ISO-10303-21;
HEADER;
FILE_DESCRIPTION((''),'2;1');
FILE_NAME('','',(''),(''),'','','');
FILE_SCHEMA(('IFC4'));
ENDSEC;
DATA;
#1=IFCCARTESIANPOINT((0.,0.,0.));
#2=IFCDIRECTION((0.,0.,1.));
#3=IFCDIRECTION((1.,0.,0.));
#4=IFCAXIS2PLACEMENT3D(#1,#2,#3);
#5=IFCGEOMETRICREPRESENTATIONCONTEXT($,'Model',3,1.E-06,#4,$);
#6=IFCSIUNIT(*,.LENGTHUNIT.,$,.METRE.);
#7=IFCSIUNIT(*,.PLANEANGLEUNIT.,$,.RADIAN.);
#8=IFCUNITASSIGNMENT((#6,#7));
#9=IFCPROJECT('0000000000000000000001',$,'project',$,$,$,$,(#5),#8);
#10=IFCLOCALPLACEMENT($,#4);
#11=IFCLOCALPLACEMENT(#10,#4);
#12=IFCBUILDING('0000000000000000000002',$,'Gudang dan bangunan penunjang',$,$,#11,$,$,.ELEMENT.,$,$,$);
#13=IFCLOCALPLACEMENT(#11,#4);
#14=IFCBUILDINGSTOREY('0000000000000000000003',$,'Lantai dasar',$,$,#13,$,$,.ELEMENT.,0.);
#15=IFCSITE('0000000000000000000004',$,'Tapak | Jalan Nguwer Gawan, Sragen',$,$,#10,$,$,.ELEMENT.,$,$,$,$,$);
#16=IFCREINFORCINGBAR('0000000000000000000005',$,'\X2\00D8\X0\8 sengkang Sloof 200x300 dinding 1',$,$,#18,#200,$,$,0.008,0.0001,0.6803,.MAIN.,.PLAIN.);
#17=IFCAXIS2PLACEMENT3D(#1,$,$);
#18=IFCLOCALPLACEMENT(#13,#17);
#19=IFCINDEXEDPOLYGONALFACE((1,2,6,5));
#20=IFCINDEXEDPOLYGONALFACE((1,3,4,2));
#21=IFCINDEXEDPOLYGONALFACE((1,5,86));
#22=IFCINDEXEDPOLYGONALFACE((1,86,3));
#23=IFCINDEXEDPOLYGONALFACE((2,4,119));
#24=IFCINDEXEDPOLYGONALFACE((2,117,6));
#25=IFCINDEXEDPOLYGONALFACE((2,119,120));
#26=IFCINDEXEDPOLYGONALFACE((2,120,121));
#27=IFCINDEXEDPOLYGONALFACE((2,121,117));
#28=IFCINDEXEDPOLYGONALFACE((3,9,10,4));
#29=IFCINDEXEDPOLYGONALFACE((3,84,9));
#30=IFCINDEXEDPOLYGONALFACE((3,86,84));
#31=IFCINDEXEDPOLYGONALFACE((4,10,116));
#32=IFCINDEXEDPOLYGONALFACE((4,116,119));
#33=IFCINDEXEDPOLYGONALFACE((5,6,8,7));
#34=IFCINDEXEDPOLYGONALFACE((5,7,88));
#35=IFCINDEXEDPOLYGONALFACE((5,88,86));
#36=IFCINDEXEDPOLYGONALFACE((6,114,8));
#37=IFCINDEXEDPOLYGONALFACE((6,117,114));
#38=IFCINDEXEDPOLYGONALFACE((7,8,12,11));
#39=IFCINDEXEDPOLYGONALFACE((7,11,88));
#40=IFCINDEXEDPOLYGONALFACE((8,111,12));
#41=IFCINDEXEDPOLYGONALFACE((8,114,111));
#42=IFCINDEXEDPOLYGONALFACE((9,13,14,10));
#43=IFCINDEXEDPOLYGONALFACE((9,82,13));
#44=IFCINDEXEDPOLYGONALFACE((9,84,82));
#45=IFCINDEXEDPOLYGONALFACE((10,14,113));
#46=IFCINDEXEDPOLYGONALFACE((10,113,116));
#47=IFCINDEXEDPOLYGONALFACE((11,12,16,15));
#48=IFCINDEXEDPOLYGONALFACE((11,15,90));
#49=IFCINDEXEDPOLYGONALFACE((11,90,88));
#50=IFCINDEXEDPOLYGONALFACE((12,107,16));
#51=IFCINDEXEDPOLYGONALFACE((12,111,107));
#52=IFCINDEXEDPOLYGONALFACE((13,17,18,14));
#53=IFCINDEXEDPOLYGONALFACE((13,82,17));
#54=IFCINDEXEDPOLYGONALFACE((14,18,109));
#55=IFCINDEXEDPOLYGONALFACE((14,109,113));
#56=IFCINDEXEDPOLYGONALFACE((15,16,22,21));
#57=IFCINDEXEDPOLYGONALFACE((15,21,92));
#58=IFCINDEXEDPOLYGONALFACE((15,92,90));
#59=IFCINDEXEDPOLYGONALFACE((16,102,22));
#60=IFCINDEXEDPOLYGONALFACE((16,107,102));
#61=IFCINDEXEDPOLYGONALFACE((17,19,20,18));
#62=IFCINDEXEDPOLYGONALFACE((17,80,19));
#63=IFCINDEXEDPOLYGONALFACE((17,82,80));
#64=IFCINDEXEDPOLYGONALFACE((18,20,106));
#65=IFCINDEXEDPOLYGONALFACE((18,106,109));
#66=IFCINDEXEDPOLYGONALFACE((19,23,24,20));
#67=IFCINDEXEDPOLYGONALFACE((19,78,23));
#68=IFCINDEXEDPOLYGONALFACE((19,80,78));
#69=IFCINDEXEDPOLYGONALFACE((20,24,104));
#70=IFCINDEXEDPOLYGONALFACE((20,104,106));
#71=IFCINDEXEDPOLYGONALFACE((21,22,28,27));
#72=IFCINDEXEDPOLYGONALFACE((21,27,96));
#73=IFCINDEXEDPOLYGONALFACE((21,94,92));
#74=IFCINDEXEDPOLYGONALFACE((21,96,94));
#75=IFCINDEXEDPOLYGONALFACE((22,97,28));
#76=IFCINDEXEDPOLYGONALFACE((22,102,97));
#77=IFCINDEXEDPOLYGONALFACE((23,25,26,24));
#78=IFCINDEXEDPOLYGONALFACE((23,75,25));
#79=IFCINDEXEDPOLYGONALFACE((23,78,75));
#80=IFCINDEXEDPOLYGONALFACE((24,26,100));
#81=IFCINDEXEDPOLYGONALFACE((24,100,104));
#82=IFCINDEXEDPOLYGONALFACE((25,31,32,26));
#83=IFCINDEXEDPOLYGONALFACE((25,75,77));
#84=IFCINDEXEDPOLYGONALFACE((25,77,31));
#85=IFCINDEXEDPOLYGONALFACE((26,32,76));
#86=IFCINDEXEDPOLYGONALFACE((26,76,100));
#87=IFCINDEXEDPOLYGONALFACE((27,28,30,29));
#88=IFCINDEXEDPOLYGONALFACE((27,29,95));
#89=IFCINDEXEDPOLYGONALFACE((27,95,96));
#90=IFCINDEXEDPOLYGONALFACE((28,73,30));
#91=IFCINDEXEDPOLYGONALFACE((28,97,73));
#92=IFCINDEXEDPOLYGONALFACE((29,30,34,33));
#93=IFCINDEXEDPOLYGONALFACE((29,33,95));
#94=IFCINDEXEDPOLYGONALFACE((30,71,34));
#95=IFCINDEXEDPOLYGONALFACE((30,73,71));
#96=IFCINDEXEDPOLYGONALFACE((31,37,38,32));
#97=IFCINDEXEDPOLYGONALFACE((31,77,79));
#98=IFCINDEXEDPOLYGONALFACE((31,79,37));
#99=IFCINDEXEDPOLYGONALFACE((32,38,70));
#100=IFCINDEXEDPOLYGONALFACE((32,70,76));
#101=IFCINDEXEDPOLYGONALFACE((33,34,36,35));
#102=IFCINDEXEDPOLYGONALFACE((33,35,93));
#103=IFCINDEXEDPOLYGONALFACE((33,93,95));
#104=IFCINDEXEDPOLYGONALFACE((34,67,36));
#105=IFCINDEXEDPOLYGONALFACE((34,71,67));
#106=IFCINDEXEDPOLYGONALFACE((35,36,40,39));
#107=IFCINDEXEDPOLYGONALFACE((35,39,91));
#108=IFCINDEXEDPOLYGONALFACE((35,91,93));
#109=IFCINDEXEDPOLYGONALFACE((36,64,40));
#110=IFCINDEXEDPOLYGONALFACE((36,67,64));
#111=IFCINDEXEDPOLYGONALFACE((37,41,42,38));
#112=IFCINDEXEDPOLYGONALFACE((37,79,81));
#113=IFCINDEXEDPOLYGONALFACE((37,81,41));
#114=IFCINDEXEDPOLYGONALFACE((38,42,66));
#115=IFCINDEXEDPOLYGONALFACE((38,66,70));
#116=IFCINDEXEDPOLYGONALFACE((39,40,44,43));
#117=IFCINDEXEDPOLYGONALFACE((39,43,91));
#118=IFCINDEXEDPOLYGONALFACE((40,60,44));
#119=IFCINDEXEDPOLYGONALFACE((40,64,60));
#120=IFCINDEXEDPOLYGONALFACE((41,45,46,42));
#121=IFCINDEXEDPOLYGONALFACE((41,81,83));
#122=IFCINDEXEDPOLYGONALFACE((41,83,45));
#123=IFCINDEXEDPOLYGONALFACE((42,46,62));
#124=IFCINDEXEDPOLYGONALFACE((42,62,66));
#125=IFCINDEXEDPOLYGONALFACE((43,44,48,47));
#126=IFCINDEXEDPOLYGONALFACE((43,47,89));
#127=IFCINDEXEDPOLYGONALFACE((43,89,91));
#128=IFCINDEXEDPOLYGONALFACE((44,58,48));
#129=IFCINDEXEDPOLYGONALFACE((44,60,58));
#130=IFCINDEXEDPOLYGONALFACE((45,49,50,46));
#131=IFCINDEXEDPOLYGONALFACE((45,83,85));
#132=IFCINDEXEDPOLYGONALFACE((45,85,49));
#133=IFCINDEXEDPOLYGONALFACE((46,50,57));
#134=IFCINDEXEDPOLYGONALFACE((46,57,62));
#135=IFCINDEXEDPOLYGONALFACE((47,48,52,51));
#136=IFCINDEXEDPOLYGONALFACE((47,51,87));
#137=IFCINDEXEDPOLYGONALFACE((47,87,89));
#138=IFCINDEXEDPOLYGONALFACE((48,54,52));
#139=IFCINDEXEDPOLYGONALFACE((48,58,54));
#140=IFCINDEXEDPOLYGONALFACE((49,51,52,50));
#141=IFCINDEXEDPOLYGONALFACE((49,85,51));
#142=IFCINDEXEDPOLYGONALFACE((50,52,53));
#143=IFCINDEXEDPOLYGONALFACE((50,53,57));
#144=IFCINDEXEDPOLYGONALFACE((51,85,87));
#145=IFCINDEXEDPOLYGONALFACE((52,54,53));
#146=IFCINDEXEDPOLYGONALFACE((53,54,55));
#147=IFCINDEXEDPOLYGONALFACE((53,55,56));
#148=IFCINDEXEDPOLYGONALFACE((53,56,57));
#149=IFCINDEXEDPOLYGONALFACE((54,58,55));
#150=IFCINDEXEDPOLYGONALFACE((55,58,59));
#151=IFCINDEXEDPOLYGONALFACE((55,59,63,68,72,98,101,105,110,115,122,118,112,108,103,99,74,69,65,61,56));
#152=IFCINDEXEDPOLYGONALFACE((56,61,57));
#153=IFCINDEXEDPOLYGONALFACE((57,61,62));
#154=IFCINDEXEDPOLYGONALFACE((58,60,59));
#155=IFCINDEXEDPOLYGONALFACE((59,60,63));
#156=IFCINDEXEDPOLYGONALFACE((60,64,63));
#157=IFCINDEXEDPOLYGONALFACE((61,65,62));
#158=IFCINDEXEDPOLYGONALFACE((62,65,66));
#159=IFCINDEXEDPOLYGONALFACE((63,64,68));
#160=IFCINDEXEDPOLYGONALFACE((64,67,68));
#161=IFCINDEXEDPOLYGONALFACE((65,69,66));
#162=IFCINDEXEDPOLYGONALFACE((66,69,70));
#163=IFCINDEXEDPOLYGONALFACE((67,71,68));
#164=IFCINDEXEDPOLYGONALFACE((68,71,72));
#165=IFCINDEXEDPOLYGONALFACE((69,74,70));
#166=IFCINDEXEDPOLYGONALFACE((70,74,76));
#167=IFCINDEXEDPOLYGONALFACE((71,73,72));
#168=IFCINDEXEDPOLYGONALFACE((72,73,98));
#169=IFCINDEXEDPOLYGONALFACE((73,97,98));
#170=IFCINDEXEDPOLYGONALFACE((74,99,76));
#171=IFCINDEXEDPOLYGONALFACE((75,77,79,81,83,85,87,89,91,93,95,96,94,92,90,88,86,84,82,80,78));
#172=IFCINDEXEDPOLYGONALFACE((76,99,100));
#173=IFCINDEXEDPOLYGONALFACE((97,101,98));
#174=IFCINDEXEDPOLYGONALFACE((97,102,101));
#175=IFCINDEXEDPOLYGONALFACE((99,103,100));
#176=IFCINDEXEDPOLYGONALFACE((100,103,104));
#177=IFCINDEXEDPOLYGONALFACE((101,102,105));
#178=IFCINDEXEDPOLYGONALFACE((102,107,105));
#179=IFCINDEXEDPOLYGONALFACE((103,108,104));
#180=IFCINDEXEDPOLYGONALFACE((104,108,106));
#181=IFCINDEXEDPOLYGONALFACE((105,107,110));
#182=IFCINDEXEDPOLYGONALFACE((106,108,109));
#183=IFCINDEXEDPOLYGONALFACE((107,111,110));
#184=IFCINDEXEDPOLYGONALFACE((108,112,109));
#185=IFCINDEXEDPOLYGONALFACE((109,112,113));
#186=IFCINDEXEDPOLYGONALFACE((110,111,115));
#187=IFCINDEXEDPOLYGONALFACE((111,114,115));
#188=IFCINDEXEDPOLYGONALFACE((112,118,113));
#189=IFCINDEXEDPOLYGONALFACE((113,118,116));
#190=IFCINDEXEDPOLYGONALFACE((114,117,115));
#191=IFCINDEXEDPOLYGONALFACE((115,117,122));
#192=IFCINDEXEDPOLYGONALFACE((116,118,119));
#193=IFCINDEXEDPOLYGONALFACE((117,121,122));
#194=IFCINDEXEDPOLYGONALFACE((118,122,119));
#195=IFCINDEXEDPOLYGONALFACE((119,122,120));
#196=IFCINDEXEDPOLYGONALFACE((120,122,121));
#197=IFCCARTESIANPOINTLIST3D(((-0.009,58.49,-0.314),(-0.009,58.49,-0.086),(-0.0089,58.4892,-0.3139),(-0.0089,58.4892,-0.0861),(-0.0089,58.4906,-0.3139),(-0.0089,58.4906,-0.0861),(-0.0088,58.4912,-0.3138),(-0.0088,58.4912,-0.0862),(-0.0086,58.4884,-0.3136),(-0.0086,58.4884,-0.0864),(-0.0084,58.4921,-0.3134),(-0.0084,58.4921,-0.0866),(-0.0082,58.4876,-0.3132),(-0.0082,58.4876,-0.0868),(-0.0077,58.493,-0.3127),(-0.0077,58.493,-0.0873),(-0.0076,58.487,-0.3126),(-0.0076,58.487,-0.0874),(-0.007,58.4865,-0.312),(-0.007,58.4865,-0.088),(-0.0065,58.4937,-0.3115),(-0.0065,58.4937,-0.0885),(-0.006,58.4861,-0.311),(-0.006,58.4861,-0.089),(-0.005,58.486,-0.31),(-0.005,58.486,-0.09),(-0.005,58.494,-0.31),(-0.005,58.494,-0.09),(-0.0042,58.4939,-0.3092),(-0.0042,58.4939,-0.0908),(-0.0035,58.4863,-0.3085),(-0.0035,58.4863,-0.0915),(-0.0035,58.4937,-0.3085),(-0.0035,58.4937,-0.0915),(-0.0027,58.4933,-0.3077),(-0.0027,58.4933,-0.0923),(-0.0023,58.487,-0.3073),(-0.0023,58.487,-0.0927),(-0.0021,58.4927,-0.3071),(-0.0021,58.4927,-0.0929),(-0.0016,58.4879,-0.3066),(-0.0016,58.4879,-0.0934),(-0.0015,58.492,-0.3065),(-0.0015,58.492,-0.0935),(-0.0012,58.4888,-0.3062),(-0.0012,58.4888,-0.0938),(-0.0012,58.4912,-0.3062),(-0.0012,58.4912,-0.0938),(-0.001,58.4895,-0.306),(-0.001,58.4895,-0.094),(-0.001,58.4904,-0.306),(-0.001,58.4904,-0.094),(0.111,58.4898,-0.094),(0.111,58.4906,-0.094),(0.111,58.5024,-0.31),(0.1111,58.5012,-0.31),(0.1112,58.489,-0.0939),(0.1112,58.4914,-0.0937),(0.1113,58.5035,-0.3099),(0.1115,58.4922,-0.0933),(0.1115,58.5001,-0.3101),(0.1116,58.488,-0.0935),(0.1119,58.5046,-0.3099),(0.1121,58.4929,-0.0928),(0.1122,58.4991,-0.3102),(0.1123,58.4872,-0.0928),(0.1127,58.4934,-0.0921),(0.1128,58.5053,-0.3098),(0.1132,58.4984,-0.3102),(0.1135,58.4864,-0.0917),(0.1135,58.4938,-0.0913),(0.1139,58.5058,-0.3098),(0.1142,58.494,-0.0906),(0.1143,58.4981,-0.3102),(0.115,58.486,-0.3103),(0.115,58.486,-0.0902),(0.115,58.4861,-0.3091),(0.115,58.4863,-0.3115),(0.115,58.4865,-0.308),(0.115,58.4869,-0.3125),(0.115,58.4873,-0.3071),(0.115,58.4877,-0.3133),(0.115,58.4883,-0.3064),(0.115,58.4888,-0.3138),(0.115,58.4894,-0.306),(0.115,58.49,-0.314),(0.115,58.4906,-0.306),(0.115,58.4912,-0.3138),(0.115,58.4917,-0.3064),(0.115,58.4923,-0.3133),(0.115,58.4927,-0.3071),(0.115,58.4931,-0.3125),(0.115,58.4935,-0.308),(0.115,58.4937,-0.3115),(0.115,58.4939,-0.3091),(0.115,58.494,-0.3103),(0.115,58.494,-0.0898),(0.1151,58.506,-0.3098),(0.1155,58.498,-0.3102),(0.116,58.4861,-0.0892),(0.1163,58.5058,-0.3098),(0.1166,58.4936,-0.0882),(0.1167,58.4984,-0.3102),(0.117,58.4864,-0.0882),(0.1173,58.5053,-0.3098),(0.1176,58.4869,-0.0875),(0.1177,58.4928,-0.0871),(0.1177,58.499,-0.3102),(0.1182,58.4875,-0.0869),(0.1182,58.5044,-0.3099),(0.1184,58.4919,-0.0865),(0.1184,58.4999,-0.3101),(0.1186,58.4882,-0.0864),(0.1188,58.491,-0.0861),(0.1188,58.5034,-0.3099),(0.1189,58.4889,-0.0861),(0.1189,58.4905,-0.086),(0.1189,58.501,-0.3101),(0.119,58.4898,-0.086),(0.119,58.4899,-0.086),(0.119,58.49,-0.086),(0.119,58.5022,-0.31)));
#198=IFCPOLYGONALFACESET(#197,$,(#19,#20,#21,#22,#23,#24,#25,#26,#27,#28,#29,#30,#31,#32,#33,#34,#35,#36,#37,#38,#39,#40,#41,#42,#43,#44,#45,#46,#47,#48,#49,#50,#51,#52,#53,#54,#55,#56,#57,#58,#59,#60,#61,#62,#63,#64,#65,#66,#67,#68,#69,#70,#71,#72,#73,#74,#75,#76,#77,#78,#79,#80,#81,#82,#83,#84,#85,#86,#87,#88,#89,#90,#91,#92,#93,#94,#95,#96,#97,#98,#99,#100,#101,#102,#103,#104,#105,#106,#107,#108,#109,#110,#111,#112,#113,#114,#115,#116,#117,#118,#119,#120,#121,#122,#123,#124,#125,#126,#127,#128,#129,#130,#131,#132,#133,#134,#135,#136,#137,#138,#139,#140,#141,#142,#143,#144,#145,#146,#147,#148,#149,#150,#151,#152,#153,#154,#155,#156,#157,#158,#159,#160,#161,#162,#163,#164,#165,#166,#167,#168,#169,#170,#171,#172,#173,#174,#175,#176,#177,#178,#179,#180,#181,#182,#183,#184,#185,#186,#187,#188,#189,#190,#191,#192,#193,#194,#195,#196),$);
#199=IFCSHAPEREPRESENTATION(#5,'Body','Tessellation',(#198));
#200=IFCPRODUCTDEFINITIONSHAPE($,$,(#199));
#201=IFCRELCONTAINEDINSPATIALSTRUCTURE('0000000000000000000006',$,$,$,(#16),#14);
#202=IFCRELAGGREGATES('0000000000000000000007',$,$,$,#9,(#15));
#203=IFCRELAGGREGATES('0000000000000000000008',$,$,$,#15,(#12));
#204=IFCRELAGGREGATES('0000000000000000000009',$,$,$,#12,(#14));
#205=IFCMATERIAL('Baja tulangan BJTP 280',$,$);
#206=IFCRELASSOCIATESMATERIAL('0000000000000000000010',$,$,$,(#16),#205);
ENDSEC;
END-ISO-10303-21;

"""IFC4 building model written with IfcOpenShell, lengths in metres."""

from ifc_helpers import new_model, entity, si_unit, origin_with_axes, place, context, project, spatial, material, element, save


model = new_model("IFC4")

# Units and contexts
model_context = context("Model", 3, precision=1e-06, world=origin_with_axes())
ifc_project = project(units=[si_unit("LENGTHUNIT", "METRE"), si_unit("PLANEANGLEUNIT", "RADIAN")], contexts=[model_context])

# Site, building, storey
site_placement = place(None, origin_with_axes())
site = spatial("IfcSite", under=ifc_project, at=site_placement, Name="Tapak | Jalan Nguwer Gawan, Sragen", CompositionType="ELEMENT")
building_placement = place(site_placement, origin_with_axes())
building = spatial("IfcBuilding", under=site, at=building_placement, Name="Gudang dan bangunan penunjang", CompositionType="ELEMENT")
storey_placement = place(building_placement, origin_with_axes())
storey = spatial("IfcBuildingStorey", under=building, at=storey_placement, Name="Lantai dasar", CompositionType="ELEMENT", Elevation=0.0)

# Shared definitions
placement = place(None, origin_with_axes())

# Reinforcing bar
ifc_material_1 = material(Name="Baja tulangan BJTP 280")
element("IfcReinforcingBar", 1, at=placement, inside=storey, material=ifc_material_1, Name="Ø8 sengkang Sloof 200x300 dinding 1", BarLength=0.6803, BarSurface="PLAIN", CrossSectionArea=0.0001, NominalDiameter=0.008, PredefinedType="MAIN", context=model_context, shape_type="AdvancedSweptSolid", body=[
    entity("IfcSweptDiskSolid", entity("IfcPolyline", [entity("IfcCartesianPoint", [0.115, 58.49, -0.31]), entity("IfcCartesianPoint", [-0.005, 58.49, -0.31]), entity("IfcCartesianPoint", [-0.005, 58.49, -0.09]), entity("IfcCartesianPoint", [0.115, 58.49, -0.09]), entity("IfcCartesianPoint", [0.115, 58.502, -0.31])]), 0.004),
])

save(model, "model.ifc")
